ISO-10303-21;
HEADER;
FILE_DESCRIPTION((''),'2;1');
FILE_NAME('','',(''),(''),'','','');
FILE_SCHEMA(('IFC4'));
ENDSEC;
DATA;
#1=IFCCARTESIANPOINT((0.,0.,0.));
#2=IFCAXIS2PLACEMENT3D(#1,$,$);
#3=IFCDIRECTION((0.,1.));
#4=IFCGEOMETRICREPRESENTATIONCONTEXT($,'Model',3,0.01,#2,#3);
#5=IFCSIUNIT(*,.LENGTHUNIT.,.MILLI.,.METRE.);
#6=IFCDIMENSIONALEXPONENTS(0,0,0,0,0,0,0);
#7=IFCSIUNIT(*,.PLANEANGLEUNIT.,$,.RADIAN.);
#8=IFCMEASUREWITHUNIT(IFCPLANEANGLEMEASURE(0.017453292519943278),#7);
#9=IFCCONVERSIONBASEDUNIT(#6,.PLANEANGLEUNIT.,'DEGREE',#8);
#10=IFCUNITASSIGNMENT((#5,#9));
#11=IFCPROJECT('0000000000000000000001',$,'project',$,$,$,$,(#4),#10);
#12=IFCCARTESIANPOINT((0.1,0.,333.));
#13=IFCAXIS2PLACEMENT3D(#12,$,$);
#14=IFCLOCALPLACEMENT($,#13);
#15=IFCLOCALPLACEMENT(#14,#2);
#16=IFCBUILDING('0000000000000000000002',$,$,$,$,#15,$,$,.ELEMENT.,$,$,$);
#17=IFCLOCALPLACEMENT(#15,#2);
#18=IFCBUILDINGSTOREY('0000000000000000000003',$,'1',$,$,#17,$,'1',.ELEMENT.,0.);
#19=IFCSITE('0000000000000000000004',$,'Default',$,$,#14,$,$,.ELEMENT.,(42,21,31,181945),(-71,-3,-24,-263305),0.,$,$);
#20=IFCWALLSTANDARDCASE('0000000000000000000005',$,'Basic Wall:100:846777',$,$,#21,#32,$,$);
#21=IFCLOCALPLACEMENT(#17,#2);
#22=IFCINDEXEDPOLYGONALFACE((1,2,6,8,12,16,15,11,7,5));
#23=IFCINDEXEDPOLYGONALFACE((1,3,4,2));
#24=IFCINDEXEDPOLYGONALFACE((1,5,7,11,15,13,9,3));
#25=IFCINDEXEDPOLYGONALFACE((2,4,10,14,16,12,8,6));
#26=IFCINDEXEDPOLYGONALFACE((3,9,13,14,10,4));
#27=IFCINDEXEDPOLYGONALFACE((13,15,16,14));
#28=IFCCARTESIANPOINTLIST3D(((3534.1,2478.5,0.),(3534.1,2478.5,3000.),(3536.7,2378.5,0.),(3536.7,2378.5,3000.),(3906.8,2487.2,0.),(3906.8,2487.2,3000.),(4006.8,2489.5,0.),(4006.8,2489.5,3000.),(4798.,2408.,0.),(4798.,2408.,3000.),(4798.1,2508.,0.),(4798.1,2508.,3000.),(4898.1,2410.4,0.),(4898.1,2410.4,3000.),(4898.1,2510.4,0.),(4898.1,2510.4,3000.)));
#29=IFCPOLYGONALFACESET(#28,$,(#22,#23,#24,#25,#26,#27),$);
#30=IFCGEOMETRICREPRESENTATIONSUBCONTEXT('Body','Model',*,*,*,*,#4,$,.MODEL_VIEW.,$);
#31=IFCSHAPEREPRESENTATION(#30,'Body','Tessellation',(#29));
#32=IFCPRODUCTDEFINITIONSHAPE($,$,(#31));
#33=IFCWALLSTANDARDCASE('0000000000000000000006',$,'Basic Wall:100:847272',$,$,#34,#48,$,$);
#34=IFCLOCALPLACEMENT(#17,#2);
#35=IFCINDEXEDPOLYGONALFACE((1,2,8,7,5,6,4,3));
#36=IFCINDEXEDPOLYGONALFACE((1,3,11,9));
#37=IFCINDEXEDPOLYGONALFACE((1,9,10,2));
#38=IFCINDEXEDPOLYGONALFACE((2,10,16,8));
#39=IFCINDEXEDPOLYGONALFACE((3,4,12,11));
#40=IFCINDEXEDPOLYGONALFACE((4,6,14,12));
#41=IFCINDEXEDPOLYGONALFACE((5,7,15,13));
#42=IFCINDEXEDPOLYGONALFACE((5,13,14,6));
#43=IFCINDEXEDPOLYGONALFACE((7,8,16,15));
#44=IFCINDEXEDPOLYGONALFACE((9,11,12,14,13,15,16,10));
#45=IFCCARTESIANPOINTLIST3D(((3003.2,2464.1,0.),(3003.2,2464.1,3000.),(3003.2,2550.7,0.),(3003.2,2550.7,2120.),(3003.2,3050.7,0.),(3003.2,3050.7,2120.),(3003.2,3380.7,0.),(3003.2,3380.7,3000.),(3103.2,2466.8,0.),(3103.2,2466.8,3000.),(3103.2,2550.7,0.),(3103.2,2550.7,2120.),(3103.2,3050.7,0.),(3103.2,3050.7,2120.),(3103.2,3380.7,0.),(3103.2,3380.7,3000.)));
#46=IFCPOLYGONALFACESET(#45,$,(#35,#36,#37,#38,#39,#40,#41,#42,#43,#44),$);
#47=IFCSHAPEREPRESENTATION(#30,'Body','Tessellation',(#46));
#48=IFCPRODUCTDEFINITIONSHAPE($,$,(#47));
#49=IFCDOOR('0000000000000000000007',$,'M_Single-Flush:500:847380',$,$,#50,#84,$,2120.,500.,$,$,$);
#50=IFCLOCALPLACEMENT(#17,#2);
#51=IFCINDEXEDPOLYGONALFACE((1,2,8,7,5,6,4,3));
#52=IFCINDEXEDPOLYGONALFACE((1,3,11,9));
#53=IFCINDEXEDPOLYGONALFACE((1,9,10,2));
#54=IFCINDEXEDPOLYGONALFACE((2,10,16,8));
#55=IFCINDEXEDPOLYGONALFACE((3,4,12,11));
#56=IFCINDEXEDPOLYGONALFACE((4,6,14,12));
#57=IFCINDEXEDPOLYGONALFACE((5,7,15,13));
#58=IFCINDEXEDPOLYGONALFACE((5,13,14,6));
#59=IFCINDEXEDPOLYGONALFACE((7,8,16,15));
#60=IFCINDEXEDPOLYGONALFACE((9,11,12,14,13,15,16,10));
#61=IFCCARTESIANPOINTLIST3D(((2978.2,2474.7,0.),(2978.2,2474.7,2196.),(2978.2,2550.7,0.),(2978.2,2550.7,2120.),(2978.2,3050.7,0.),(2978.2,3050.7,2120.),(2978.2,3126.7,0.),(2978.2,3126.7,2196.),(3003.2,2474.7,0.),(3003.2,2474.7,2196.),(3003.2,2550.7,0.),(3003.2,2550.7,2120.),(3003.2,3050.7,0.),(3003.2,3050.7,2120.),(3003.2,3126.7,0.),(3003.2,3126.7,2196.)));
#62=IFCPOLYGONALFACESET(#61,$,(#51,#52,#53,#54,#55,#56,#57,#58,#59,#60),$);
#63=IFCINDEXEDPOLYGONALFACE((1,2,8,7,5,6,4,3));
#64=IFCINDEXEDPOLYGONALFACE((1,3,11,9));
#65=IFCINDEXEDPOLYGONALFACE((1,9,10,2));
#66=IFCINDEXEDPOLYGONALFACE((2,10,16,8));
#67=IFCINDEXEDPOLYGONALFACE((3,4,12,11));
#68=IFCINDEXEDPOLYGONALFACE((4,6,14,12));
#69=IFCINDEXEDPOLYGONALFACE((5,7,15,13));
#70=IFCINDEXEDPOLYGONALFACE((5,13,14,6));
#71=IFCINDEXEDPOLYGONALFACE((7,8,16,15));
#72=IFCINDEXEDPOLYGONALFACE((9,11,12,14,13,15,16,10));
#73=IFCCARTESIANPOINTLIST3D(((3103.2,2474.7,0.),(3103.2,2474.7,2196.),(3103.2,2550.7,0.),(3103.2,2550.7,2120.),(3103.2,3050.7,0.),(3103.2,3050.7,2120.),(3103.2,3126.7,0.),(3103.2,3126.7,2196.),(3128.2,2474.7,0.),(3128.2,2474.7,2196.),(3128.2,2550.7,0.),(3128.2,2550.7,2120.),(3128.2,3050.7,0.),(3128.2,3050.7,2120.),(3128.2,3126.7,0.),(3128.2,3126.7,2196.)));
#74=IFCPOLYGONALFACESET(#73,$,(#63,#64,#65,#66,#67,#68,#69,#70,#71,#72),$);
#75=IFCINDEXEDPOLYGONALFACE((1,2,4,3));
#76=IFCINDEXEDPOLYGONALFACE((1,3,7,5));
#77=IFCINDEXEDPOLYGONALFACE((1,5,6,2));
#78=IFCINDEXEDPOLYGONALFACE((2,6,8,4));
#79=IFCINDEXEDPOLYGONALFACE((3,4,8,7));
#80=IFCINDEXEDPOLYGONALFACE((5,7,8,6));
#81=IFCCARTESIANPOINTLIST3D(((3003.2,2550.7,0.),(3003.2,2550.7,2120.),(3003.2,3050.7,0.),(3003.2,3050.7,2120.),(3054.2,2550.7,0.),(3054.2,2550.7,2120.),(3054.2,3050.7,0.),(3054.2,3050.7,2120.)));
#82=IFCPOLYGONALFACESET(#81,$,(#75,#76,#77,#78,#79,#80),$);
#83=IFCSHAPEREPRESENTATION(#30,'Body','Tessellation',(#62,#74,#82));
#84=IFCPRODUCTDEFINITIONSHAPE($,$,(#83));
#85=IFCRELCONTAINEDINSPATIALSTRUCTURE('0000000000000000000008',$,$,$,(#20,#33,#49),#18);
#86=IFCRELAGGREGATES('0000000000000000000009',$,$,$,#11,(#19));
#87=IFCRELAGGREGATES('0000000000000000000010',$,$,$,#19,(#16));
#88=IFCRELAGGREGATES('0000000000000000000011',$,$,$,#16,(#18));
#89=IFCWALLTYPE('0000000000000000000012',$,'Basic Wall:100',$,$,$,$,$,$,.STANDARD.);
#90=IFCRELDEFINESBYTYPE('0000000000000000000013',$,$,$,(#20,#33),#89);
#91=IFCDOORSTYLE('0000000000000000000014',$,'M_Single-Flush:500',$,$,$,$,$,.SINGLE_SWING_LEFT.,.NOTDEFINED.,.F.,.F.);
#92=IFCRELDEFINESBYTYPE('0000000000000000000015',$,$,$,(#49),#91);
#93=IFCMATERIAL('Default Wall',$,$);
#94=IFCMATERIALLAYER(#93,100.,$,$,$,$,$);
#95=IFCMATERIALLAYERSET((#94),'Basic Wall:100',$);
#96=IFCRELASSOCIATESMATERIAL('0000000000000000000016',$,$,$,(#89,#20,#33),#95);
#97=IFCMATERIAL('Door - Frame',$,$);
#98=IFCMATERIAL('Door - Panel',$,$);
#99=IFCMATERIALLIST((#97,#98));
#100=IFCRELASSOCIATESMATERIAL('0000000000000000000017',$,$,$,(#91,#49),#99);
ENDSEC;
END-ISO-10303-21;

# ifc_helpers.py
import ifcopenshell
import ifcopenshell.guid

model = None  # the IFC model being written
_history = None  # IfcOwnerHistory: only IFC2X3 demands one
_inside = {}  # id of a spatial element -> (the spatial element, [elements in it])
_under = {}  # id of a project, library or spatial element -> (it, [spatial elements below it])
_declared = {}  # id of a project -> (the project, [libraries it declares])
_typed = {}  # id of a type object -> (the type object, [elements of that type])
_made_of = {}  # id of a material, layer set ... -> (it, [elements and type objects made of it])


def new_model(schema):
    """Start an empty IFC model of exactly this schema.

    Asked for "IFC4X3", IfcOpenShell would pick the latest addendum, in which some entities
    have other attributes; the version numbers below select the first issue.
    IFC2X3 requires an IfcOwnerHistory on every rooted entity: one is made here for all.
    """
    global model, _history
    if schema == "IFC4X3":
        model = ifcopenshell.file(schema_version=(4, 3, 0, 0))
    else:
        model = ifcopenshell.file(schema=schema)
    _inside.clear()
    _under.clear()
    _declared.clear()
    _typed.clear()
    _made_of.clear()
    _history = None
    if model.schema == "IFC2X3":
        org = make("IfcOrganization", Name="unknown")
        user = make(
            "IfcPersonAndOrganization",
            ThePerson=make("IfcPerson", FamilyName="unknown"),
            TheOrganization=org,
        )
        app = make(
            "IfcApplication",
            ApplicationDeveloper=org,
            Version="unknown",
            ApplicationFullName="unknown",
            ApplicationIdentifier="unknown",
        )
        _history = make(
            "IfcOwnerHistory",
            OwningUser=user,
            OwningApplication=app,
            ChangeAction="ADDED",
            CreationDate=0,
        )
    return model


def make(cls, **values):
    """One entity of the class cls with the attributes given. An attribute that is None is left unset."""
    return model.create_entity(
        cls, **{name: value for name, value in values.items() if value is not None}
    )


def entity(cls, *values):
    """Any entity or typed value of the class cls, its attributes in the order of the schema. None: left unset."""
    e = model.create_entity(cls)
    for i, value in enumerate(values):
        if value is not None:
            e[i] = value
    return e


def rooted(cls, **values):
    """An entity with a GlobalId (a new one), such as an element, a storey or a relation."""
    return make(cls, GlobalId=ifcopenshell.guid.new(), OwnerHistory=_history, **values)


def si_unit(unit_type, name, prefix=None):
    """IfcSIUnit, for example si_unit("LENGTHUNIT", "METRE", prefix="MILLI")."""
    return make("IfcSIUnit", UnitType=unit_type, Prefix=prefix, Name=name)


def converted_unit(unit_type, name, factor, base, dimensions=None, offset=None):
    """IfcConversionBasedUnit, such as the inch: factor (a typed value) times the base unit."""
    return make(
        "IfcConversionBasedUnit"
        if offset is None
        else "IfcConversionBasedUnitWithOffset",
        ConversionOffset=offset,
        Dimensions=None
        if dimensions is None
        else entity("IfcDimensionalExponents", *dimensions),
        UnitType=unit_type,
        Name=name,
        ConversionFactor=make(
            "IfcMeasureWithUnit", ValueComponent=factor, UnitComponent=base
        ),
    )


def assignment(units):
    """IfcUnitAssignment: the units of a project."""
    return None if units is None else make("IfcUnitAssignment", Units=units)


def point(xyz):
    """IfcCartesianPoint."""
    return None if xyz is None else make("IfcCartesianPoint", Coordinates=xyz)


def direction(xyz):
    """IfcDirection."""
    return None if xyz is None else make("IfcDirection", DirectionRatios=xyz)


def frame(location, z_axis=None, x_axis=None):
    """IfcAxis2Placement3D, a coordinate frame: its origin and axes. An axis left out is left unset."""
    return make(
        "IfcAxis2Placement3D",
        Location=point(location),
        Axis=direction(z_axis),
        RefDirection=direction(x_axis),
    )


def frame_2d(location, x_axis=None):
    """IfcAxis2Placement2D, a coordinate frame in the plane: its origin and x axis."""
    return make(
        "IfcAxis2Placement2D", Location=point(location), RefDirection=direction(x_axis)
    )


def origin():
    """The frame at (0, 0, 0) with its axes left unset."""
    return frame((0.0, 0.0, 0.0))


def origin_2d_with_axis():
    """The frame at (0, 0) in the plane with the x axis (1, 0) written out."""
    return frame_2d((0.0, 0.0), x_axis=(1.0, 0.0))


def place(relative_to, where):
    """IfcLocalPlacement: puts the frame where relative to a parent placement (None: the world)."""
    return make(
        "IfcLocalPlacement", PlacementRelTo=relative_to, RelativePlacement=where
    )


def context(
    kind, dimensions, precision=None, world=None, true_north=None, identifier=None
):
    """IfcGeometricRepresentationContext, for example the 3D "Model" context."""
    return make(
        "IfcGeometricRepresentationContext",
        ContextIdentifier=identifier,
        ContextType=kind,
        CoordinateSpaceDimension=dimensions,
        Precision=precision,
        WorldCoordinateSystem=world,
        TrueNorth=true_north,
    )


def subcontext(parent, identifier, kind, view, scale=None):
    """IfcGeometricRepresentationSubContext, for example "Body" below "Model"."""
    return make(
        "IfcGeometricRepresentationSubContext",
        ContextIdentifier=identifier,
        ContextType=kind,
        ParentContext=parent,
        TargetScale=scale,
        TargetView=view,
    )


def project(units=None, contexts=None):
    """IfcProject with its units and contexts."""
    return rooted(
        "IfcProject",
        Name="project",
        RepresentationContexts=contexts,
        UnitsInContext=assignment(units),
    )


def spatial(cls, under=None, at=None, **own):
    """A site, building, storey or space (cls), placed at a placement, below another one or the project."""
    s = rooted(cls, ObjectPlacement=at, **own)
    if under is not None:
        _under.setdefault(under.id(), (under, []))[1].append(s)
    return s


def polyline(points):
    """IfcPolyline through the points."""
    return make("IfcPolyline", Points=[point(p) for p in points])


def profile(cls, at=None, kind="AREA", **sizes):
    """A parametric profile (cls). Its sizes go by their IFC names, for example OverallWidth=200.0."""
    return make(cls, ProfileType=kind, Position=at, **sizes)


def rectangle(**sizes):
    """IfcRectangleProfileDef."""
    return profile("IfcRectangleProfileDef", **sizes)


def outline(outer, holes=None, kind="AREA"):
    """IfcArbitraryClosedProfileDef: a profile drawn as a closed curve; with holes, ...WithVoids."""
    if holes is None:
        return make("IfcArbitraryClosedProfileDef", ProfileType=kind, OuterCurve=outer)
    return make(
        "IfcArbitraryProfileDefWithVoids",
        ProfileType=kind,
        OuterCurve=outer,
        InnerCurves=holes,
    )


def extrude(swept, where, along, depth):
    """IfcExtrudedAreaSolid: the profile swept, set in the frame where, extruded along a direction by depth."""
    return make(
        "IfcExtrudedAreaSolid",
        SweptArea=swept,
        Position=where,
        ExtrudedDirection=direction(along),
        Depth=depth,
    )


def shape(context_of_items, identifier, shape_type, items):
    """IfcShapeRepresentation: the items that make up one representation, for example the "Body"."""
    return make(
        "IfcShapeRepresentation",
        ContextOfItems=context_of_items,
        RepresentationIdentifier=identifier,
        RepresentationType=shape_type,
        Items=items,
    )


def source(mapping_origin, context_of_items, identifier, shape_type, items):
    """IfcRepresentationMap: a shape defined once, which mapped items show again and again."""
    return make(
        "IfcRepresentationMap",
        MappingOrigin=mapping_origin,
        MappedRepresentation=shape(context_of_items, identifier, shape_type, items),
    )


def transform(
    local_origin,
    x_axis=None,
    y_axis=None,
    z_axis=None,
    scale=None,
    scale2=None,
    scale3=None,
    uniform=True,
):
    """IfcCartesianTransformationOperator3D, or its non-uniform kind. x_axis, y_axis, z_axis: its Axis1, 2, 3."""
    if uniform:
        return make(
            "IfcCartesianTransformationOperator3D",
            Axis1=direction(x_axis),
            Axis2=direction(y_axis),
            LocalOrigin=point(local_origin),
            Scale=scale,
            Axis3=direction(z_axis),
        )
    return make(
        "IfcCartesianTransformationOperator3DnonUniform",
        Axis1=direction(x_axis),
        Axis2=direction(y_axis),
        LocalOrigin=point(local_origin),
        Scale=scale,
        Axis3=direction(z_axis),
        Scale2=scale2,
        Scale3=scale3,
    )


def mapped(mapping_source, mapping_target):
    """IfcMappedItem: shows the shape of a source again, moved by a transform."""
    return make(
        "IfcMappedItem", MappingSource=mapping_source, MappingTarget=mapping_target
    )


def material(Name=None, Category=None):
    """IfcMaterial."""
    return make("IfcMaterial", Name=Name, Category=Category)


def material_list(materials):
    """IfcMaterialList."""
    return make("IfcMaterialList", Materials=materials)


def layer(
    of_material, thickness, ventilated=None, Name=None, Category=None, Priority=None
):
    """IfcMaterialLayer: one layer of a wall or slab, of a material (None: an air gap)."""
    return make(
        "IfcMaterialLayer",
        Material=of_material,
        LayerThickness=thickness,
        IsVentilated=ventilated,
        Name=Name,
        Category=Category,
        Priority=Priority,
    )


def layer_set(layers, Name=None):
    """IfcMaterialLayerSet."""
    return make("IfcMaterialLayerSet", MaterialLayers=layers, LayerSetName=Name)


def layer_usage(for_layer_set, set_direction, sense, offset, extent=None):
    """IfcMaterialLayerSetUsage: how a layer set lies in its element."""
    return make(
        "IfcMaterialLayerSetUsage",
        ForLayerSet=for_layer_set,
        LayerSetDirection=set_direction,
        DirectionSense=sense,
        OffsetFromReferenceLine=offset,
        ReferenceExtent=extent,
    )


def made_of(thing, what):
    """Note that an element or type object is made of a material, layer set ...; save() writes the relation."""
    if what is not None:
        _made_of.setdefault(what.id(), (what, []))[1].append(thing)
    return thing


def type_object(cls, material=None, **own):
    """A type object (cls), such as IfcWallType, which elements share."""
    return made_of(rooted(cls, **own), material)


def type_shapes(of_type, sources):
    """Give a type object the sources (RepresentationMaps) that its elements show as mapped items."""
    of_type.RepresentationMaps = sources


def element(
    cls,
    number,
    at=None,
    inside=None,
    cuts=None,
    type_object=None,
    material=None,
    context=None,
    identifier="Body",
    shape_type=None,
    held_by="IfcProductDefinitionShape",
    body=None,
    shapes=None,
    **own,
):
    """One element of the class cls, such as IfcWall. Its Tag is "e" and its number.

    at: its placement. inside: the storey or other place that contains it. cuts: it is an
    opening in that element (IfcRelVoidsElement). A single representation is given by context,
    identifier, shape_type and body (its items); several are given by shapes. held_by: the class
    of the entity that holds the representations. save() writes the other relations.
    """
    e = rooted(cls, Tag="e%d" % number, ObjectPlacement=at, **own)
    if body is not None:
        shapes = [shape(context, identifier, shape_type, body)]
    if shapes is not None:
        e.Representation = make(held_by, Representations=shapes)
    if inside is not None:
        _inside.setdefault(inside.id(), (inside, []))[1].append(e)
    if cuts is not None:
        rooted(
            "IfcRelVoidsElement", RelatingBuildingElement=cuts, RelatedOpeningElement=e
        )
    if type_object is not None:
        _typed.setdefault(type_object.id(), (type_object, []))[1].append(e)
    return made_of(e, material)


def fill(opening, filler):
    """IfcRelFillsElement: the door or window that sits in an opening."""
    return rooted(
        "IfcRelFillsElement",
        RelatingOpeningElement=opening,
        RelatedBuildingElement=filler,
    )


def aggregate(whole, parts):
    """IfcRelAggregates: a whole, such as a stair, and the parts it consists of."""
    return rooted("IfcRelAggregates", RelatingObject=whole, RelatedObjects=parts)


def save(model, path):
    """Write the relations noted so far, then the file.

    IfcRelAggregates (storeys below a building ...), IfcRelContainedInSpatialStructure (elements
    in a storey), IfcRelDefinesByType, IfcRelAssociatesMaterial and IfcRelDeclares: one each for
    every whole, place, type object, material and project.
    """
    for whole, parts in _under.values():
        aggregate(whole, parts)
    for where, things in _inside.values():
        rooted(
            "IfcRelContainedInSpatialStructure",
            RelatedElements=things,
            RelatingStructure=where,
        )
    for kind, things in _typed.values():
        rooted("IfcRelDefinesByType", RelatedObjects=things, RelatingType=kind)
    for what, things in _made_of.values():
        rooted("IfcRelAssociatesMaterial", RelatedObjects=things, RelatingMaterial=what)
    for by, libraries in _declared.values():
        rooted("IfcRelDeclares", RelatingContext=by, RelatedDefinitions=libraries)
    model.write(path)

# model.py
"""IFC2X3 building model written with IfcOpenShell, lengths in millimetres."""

from ifc_helpers import new_model, entity, si_unit, converted_unit, direction, frame, frame_2d, origin, origin_2d_with_axis, place, context, subcontext, project, spatial, polyline, rectangle, outline, extrude, source, transform, mapped, material, material_list, layer, layer_set, layer_usage, type_object, type_shapes, element, fill, save


model = new_model("IFC2X3")

# Units and contexts
model_context = context("Model", 3, precision=0.01, world=origin(), true_north=direction((0.0, 1.0)))
body_context = subcontext(model_context, "Body", "Model", "MODEL_VIEW")
ifc_project = project(units=[si_unit("LENGTHUNIT", "METRE", prefix="MILLI"), converted_unit("PLANEANGLEUNIT", "DEGREE", entity("IfcPlaneAngleMeasure", 0.017453292519943278), si_unit("PLANEANGLEUNIT", "RADIAN"), dimensions=[0, 0, 0, 0, 0, 0, 0])], contexts=[model_context])

# Site, building, storey
site_placement = place(None, frame((0.1, 0.0, 333.0)))
site = spatial("IfcSite", under=ifc_project, at=site_placement, Name="Default", CompositionType="ELEMENT", RefLatitude=(42, 21, 31, 181945), RefLongitude=(-71, -3, -24, -263305), RefElevation=0.0)
building_placement = place(site_placement, origin())
building = spatial("IfcBuilding", under=site, at=building_placement, CompositionType="ELEMENT")
storey_placement = place(building_placement, origin())
storey = spatial("IfcBuildingStorey", under=building, at=storey_placement, Name="1", LongName="1", CompositionType="ELEMENT", Elevation=0.0)

# Shared definitions
ifc_material_1 = material(Name="Default Wall")

# Shared definitions
ifc_layer_1 = layer(ifc_material_1, 100.0)
ifc_layer_set_1 = layer_set([ifc_layer_1], Name="Basic Wall:100")
wall_type_1 = type_object("IfcWallType", Name="Basic Wall:100", PredefinedType="STANDARD", material=ifc_layer_set_1)

# Shared definitions
ifc_material_2 = material(Name="Door - Frame")
ifc_material_3 = material(Name="Door - Panel")
ifc_material_list_1 = material_list([ifc_material_2, ifc_material_3])

# Wall
ifc_layer_usage_1 = layer_usage(ifc_layer_set_1, "AXIS2", "NEGATIVE", 50.0)
wall_1_placement = place(storey_placement, frame((3535.3, 2428.5, 0.0), z_axis=(0.0, 0.0, 1.0), x_axis=(0.999727, 0.023385, 0.0)))
element("IfcWallStandardCase", 1, at=wall_1_placement, inside=storey, type_object=wall_type_1, material=ifc_layer_usage_1, Name="Basic Wall:100:846777", context=body_context, shape_type="SweptSolid", body=[
    extrude(outline(polyline([(1362.0, -50.0), (1364.3, 50.0), (1264.3, 50.0), (472.8, 50.0), (372.8, 50.0), (0.0, 50.0), (0.2, -50.0), (1261.9, -50.0), (1362.0, -50.0)])), origin(), (0.0, 0.0, 1.0), 3000.0),
])

# Wall, opening, door
ifc_layer_usage_2 = layer_usage(ifc_layer_set_1, "AXIS2", "POSITIVE", -50.0)
wall_2_placement = place(storey_placement, frame((3053.2, 3380.7, 0.0), z_axis=(0.0, 0.0, 1.0), x_axis=(0.0, -1.0, 0.0)))
wall_2 = element("IfcWallStandardCase", 2, at=wall_2_placement, inside=storey, type_object=wall_type_1, material=ifc_layer_usage_2, Name="Basic Wall:100:847272", context=body_context, shape_type="SweptSolid", body=[
    extrude(outline(polyline([(0.0, -50.0), (916.6, -50.0), (913.9, 50.0), (0.0, 50.0), (0.0, -50.0)])), origin(), (0.0, 0.0, 1.0), 3000.0),
])
opening_1_placement = place(wall_2_placement, frame((829.9, 50.0, 0.0)))
opening_1 = element("IfcOpeningElement", 3, at=opening_1_placement, cuts=wall_2, ObjectType="Opening", context=body_context, shape_type="SweptSolid", body=[
    extrude(rectangle(XDim=500.0, YDim=2120.0, at=frame_2d((1060.0, 250.0), x_axis=(0.0, -1.0))), frame((0.0, 0.0, 0.0), z_axis=(0.0, -1.0, 0.0), x_axis=(0.0, 0.0, 1.0)), (0.0, 0.0, 1.0), 100.0),
])
door_style_1 = type_object("IfcDoorStyle", Name="M_Single-Flush:500", ConstructionType="NOTDEFINED", OperationType="SINGLE_SWING_LEFT", ParameterTakesPrecedence=False, Sizeable=False, material=ifc_material_list_1)
shared_shape_1 = source(origin(), body_context, "Body", "SweptSolid", [
    extrude(outline(polyline([(-326.0, -1117.0), (326.0, -1117.0), (326.0, 1079.0), (250.0, 1079.0), (250.0, -1041.0), (-250.0, -1041.0), (-250.0, 1079.0), (-326.0, 1079.0), (-326.0, -1117.0)])), frame((250.0, 125.0, 1079.0), z_axis=(0.0, -1.0, 0.0), x_axis=(-1.0, 0.0, 0.0)), (0.0, 0.0, 1.0), 25.0),
    extrude(outline(polyline([(-1117.0, -326.0), (1079.0, -326.0), (1079.0, -250.0), (-1041.0, -250.0), (-1041.0, 250.0), (1079.0, 250.0), (1079.0, 326.0), (-1117.0, 326.0), (-1117.0, -326.0)])), frame((250.0, 0.0, 1079.0), z_axis=(0.0, -1.0, 0.0), x_axis=(0.0, 0.0, -1.0)), (0.0, 0.0, 1.0), 25.0),
    extrude(rectangle(XDim=500.0, YDim=51.0, at=origin_2d_with_axis()), frame((250.0, 74.5, 0.0)), (0.0, 0.0, 1.0), 2120.0),
])
type_shapes(door_style_1, [shared_shape_1])
door_1_placement = place(opening_1_placement, frame((0.0, 0.0, 0.0), z_axis=(0.0, 0.0, 1.0), x_axis=(-1.0, 0.0, 0.0)))
door_1 = element("IfcDoor", 4, at=door_1_placement, inside=storey, type_object=door_style_1, material=ifc_material_list_1, Name="M_Single-Flush:500:847380", OverallHeight=2120.0, OverallWidth=500.0, context=body_context, shape_type="MappedRepresentation", body=[
    mapped(shared_shape_1, transform((0.0, 0.0, 0.0), scale=1.0)),
])
fill(opening_1, door_1)

save(model, "model.ifc")
